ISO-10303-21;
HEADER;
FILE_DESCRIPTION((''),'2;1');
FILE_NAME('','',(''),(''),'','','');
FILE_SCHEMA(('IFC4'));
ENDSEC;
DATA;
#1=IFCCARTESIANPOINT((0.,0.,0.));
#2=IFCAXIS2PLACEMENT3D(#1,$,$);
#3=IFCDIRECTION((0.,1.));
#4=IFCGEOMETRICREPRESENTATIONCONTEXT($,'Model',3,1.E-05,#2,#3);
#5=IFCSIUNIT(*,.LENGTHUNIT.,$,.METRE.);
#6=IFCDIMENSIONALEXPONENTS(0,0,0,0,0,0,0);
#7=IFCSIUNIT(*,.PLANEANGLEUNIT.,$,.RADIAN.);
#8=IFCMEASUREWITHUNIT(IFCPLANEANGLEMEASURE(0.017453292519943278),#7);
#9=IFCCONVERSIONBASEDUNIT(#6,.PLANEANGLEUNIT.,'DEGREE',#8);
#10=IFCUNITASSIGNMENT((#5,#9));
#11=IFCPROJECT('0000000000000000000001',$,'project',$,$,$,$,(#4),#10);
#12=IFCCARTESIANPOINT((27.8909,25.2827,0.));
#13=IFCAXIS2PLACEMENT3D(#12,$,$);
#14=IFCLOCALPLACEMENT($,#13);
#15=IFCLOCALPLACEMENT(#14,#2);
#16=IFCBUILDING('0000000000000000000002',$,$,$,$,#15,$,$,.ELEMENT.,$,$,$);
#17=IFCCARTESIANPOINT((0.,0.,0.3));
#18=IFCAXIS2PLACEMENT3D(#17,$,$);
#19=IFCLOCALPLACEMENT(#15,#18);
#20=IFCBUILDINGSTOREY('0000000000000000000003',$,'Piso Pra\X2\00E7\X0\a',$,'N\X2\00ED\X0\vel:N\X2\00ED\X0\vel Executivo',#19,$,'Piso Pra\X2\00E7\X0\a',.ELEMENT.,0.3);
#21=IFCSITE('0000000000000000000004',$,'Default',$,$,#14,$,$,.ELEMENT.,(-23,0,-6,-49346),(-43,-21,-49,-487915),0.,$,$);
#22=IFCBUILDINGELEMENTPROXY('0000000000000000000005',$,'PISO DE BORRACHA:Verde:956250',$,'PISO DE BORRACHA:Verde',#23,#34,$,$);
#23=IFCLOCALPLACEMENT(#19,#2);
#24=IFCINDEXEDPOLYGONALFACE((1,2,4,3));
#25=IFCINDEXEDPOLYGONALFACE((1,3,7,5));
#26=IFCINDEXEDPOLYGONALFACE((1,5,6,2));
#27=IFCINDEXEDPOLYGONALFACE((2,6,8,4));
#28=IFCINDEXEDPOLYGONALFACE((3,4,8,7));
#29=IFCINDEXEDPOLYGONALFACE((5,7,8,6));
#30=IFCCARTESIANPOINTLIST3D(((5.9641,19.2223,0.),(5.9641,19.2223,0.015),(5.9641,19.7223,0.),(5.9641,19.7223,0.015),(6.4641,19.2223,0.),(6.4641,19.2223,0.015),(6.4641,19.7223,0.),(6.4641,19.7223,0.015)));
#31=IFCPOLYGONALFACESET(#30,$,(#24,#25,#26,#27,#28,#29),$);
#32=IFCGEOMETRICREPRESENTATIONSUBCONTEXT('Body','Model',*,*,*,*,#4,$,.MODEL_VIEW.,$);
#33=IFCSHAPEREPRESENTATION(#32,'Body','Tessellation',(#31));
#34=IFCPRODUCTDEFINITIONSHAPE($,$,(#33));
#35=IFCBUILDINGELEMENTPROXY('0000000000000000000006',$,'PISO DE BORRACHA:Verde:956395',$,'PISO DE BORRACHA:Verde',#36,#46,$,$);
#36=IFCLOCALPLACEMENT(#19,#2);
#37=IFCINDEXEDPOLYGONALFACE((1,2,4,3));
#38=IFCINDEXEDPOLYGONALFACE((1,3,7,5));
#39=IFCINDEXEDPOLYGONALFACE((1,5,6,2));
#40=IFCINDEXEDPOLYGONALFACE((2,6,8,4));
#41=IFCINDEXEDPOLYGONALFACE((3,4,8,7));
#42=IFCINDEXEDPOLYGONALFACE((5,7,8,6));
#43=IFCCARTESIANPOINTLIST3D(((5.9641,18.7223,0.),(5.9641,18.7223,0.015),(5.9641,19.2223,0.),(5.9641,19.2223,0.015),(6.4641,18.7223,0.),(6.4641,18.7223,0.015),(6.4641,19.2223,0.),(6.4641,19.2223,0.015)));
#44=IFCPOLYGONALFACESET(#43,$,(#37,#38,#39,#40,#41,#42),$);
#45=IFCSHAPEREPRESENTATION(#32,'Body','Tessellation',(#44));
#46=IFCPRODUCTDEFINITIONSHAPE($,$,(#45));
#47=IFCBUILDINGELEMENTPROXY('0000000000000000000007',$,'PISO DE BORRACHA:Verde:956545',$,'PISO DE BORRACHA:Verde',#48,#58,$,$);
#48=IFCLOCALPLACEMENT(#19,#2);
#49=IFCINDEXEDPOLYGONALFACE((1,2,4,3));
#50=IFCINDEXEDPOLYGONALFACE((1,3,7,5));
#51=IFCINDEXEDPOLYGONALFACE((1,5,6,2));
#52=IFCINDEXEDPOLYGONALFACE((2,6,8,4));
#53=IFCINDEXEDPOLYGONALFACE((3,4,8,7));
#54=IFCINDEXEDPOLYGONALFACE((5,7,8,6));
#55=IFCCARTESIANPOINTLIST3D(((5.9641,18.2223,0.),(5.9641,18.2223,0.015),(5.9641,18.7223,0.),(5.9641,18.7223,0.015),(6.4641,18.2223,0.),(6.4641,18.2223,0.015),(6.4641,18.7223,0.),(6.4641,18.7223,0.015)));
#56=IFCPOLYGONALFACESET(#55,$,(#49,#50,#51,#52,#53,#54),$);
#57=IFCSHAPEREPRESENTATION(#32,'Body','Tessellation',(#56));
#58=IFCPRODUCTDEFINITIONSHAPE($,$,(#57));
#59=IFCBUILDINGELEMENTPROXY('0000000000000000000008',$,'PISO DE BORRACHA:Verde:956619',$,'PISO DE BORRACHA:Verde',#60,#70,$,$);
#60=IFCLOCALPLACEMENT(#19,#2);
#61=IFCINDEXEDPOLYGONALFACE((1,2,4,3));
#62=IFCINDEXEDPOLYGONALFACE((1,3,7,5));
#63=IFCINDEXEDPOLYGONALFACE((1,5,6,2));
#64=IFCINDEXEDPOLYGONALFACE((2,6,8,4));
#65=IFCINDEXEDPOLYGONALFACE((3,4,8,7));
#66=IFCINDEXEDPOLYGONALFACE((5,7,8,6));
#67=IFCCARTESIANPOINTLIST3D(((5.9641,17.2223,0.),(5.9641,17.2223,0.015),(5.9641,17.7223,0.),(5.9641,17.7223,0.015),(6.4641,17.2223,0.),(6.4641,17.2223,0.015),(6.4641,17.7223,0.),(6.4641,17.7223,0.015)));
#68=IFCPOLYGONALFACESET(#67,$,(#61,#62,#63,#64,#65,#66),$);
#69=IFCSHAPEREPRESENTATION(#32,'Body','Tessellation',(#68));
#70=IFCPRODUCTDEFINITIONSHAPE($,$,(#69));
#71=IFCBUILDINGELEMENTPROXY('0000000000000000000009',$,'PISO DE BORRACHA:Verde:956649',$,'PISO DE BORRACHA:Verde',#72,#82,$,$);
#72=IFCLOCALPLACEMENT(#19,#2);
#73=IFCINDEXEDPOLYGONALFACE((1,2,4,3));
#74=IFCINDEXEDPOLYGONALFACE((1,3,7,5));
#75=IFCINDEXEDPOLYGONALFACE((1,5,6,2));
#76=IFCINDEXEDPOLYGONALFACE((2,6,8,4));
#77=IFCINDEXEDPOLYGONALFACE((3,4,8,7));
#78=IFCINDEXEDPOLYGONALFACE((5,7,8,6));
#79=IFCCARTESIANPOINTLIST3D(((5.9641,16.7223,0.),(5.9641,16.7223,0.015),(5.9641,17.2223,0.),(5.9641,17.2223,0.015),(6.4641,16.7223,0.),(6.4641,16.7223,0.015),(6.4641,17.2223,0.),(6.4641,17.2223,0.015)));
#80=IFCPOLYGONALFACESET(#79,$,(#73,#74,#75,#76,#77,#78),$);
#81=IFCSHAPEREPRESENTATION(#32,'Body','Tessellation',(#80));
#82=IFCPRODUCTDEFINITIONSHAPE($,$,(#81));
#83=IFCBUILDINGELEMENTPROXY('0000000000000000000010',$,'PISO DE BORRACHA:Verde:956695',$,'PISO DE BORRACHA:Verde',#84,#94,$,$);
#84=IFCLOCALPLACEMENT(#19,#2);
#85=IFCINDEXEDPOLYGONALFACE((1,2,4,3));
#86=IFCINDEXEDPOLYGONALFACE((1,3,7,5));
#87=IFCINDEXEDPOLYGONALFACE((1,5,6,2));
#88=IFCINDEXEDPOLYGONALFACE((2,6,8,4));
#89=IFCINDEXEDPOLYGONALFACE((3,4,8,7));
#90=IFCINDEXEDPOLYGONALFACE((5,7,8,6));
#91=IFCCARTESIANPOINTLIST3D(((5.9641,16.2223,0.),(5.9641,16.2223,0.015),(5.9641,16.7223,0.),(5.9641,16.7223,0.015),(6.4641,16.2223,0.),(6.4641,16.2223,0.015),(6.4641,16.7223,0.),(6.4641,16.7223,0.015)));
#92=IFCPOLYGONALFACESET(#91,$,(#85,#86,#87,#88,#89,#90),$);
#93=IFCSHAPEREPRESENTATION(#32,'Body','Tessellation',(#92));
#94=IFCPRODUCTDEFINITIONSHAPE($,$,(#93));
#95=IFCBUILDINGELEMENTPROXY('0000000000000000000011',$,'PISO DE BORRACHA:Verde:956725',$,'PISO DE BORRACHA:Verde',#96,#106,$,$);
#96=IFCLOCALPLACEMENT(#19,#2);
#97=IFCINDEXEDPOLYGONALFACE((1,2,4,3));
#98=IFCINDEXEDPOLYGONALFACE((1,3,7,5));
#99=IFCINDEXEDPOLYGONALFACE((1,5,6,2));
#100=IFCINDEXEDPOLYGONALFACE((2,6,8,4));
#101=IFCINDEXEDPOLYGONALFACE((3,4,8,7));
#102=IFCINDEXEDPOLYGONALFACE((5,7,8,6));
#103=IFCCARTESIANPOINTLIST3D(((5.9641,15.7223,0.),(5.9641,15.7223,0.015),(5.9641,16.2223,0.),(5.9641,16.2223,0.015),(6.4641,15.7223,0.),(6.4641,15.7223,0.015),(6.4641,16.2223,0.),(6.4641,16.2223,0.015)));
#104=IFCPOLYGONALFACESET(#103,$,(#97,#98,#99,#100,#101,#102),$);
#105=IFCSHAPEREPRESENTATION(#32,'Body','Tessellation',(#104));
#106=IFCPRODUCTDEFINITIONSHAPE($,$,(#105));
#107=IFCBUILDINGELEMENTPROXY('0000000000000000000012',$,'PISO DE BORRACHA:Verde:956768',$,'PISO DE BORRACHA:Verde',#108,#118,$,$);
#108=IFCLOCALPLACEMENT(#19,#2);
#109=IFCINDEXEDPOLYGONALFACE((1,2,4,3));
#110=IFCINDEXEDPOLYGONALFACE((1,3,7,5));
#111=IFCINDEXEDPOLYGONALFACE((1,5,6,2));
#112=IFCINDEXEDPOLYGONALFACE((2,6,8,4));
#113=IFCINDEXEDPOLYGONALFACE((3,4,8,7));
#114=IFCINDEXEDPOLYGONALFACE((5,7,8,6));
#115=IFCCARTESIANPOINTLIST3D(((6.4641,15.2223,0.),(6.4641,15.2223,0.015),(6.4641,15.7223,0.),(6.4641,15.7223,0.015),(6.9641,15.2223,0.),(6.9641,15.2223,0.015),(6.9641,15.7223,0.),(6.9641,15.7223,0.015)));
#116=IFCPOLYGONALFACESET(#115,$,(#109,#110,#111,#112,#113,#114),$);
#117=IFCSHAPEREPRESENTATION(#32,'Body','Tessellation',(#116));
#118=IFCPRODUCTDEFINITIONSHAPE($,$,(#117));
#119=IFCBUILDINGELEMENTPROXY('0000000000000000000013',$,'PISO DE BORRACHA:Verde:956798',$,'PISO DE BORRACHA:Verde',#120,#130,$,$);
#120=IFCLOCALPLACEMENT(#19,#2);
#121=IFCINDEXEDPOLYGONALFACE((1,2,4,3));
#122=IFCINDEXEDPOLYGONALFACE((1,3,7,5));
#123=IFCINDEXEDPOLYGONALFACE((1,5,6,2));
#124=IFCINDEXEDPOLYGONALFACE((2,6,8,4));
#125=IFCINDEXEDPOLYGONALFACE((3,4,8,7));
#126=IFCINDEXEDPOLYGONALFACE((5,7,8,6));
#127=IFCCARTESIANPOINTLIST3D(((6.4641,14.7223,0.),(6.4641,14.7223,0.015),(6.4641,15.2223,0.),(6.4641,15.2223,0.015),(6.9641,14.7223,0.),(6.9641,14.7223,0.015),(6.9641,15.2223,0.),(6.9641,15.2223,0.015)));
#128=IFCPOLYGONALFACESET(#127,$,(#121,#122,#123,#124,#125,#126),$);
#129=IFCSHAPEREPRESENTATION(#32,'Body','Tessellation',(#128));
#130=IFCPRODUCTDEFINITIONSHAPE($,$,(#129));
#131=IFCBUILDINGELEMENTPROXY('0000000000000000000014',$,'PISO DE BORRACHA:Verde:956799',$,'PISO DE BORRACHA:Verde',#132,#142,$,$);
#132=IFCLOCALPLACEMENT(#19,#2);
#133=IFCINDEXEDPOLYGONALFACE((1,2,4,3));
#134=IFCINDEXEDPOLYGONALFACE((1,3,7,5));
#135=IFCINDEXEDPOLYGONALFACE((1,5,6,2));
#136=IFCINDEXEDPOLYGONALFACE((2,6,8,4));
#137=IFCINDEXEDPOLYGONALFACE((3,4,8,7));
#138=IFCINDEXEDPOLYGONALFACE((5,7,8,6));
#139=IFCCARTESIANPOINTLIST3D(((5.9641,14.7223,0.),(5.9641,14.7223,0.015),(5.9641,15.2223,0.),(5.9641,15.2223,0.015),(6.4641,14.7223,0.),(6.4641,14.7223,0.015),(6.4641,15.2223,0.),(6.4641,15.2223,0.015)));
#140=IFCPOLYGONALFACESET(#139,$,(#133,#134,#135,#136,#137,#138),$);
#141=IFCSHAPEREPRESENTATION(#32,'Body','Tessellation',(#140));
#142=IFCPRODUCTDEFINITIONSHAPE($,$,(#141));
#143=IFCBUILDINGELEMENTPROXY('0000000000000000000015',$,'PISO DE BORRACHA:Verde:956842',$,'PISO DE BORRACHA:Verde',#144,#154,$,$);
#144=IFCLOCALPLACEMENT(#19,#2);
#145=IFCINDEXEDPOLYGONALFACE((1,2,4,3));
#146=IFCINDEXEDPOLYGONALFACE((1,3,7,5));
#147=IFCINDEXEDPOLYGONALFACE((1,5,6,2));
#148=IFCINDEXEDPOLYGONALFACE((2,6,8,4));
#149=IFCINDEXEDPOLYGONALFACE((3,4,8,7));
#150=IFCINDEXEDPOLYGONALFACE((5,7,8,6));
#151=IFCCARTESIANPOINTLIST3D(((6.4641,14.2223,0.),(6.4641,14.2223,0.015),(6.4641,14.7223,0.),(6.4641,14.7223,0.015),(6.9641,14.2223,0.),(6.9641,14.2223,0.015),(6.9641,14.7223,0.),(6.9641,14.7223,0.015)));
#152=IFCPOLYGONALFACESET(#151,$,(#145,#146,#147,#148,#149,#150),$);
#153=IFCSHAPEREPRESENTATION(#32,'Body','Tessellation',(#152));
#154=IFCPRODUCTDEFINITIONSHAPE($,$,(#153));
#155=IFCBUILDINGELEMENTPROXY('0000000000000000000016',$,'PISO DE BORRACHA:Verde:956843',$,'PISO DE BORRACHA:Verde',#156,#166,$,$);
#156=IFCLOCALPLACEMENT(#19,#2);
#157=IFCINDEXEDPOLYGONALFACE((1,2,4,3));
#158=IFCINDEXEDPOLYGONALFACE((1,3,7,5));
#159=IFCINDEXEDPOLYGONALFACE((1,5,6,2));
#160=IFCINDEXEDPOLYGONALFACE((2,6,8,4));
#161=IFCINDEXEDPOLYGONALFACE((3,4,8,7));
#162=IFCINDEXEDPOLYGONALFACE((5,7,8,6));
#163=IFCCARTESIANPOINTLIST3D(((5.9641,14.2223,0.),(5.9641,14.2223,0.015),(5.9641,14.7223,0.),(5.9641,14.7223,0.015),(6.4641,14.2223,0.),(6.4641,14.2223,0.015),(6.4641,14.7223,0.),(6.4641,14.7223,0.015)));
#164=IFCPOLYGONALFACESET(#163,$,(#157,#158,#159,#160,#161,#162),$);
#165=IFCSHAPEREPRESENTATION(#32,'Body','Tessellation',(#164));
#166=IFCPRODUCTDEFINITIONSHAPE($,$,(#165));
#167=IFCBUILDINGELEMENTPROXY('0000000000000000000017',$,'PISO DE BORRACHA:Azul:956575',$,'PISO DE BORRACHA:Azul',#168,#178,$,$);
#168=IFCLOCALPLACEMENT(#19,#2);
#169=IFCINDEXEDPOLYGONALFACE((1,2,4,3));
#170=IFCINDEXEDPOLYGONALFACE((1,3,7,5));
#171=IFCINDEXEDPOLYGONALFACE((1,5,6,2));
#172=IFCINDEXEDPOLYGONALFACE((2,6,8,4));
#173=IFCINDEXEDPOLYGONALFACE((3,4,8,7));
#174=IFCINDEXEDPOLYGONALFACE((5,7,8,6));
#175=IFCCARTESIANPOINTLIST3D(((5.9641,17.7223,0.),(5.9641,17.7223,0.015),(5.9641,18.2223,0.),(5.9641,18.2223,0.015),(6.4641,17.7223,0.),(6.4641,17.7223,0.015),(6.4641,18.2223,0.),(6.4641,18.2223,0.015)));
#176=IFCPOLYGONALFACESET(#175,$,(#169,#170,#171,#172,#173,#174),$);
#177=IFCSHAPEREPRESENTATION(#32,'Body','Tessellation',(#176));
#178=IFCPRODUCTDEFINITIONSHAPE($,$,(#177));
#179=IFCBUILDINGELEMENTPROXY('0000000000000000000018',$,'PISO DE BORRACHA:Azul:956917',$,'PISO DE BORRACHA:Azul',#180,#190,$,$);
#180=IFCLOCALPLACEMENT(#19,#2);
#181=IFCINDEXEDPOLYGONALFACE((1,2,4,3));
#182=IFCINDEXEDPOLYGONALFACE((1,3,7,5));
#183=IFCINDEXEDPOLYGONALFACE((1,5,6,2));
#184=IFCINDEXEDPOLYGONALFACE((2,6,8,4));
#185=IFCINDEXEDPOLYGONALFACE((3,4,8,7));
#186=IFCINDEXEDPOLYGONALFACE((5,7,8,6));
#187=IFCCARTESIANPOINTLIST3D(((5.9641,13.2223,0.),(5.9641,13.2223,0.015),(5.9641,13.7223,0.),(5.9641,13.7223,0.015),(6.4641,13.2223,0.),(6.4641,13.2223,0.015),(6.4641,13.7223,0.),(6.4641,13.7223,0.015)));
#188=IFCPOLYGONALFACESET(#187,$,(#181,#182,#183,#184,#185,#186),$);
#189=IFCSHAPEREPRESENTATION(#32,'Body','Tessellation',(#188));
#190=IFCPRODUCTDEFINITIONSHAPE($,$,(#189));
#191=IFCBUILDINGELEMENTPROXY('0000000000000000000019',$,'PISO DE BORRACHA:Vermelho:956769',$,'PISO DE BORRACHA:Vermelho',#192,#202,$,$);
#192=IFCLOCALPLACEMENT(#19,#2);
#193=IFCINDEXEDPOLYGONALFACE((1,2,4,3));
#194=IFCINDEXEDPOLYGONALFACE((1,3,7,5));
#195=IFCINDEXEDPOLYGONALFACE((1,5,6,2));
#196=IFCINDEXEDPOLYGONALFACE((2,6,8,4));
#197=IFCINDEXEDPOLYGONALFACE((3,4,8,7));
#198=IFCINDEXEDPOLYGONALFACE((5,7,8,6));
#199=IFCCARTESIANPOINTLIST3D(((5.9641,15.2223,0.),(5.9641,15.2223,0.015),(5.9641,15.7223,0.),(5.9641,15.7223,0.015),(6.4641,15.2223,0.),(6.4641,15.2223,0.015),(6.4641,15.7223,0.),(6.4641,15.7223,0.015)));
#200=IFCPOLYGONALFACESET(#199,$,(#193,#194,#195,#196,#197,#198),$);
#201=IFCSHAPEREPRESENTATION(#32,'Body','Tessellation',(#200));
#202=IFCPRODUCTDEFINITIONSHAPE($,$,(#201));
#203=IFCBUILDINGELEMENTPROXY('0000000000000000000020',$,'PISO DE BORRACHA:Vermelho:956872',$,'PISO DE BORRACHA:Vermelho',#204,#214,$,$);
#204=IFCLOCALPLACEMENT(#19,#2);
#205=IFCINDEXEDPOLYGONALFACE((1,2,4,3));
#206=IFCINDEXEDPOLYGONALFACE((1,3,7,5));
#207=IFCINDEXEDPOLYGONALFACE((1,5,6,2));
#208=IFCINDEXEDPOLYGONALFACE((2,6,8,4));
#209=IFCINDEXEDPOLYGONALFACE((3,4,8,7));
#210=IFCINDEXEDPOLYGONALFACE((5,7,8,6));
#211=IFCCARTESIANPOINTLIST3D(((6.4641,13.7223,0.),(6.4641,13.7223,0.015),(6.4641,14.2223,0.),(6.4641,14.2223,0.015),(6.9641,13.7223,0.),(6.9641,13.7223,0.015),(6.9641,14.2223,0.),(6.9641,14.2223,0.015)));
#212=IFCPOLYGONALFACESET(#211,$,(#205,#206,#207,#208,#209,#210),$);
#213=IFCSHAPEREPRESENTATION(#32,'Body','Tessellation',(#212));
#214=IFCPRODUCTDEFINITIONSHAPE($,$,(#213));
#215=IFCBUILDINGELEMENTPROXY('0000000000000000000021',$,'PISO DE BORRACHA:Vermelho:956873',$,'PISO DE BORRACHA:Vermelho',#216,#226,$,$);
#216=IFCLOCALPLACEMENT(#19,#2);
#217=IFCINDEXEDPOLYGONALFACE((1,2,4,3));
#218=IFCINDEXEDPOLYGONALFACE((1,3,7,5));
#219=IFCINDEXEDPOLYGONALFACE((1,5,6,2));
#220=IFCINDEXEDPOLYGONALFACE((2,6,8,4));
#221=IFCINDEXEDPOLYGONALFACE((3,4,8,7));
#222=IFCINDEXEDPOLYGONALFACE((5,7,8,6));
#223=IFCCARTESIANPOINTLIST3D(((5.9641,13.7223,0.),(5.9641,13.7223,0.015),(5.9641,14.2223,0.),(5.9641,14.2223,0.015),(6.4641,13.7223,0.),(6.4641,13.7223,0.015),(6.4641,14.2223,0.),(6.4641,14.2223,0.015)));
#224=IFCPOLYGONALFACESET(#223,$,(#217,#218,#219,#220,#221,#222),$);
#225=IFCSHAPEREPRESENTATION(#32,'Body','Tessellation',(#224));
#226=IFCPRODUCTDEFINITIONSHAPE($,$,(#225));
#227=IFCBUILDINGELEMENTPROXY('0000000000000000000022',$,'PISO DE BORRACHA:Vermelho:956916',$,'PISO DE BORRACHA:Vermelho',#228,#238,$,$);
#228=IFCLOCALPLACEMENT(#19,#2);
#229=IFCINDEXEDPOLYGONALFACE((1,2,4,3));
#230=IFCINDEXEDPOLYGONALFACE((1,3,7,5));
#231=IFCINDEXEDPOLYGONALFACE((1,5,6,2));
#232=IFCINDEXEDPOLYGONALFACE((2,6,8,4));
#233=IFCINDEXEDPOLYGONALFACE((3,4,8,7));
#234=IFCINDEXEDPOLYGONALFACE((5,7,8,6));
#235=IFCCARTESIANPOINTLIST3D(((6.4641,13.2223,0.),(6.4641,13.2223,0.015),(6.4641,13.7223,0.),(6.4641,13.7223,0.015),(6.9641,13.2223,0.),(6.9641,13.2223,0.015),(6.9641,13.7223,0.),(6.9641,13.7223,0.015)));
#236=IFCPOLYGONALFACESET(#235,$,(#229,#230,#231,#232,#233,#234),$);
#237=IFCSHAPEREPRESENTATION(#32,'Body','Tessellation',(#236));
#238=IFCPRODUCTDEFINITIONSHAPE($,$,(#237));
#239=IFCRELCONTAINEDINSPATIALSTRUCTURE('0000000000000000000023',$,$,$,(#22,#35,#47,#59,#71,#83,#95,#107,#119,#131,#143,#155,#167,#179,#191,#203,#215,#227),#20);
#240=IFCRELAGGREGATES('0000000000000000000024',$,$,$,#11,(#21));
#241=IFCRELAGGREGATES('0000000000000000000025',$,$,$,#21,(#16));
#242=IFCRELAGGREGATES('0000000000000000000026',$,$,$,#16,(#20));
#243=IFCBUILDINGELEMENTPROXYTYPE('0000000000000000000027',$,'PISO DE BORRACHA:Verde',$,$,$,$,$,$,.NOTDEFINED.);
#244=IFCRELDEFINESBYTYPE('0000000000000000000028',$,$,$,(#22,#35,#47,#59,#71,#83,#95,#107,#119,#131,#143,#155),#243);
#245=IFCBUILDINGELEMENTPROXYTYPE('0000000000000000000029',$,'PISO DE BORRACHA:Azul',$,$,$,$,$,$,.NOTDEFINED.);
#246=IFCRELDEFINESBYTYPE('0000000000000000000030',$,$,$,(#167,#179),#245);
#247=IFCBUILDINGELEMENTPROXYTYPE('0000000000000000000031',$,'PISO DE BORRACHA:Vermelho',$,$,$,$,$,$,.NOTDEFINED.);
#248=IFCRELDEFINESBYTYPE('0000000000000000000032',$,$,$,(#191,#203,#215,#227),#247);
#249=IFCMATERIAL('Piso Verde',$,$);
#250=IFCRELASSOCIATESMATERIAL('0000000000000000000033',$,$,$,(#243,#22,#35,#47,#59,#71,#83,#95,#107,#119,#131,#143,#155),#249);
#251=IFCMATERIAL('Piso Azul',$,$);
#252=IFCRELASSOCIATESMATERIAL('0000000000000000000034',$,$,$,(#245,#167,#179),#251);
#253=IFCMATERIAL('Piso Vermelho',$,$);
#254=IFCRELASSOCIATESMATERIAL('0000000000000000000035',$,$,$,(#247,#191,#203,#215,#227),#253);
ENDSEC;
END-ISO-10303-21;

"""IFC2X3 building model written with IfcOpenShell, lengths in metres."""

from ifc_helpers import new_model, entity, si_unit, converted_unit, direction, frame, origin, origin_2d_with_axis, place, context, subcontext, project, spatial, rectangle, extrude, source, transform, mapped, material, type_object, type_shapes, element, save


model = new_model("IFC2X3")

# Units and contexts
model_context = context("Model", 3, precision=1e-05, world=origin(), true_north=direction((0.0, 1.0)))
body_context = subcontext(model_context, "Body", "Model", "MODEL_VIEW")
ifc_project = project(units=[si_unit("LENGTHUNIT", "METRE"), converted_unit("PLANEANGLEUNIT", "DEGREE", entity("IfcPlaneAngleMeasure", 0.017453292519943278), si_unit("PLANEANGLEUNIT", "RADIAN"), dimensions=[0, 0, 0, 0, 0, 0, 0])], contexts=[model_context])

# Site, building, storey
site_placement = place(None, frame((27.8909, 25.2827, 0.0)))
site = spatial("IfcSite", under=ifc_project, at=site_placement, Name="Default", CompositionType="ELEMENT", RefLatitude=(-23, 0, -6, -49346), RefLongitude=(-43, -21, -49, -487915), RefElevation=0.0)
building_placement = place(site_placement, origin())
building = spatial("IfcBuilding", under=site, at=building_placement, CompositionType="ELEMENT")
storey_placement = place(building_placement, frame((0.0, 0.0, 0.3)))
storey = spatial("IfcBuildingStorey", under=building, at=storey_placement, Name="Piso Praça", ObjectType="Nível:Nível Executivo", LongName="Piso Praça", CompositionType="ELEMENT", Elevation=0.3)

# Building element proxies
ifc_material_1 = material(Name="Piso Verde")
building_element_proxy_type_1 = type_object("IfcBuildingElementProxyType", Name="PISO DE BORRACHA:Verde", PredefinedType="NOTDEFINED", material=ifc_material_1)
shared_shape_1 = source(origin(), body_context, "Body", "SweptSolid", [
    extrude(rectangle(XDim=0.5, YDim=0.5, at=origin_2d_with_axis()), frame((0.25, 0.25, 0.0), z_axis=(0.0, 0.0, 1.0), x_axis=(-1.0, 0.0, 0.0)), (0.0, 0.0, 1.0), 0.015),
])
type_shapes(building_element_proxy_type_1, [shared_shape_1])
for number, where, name in (
    (1, (5.9641, 19.2223, 0.0), "PISO DE BORRACHA:Verde:956250"),
    (2, (5.9641, 18.7223, 0.0), "PISO DE BORRACHA:Verde:956395"),
    (3, (5.9641, 18.2223, 0.0), "PISO DE BORRACHA:Verde:956545"),
    (4, (5.9641, 17.2223, 0.0), "PISO DE BORRACHA:Verde:956619"),
    (5, (5.9641, 16.7223, 0.0), "PISO DE BORRACHA:Verde:956649"),
    (6, (5.9641, 16.2223, 0.0), "PISO DE BORRACHA:Verde:956695"),
    (7, (5.9641, 15.7223, 0.0), "PISO DE BORRACHA:Verde:956725"),
    (8, (6.4641, 15.2223, 0.0), "PISO DE BORRACHA:Verde:956768"),
    (9, (6.4641, 14.7223, 0.0), "PISO DE BORRACHA:Verde:956798"),
    (10, (5.9641, 14.7223, 0.0), "PISO DE BORRACHA:Verde:956799"),
    (11, (6.4641, 14.2223, 0.0), "PISO DE BORRACHA:Verde:956842"),
    (12, (5.9641, 14.2223, 0.0), "PISO DE BORRACHA:Verde:956843"),
):
    element("IfcBuildingElementProxy", number, at=place(storey_placement, frame(where)), inside=storey, type_object=building_element_proxy_type_1, material=ifc_material_1, Name=name, ObjectType="PISO DE BORRACHA:Verde", context=body_context, shape_type="MappedRepresentation", body=[
        mapped(shared_shape_1, transform((0.0, 0.0, 0.0), scale=1.0)),
    ])
ifc_material_2 = material(Name="Piso Azul")
building_element_proxy_type_2 = type_object("IfcBuildingElementProxyType", Name="PISO DE BORRACHA:Azul", PredefinedType="NOTDEFINED", material=ifc_material_2)
shared_shape_2 = source(origin(), body_context, "Body", "SweptSolid", [
    extrude(rectangle(XDim=0.5, YDim=0.5, at=origin_2d_with_axis()), frame((0.25, 0.25, 0.0), z_axis=(0.0, 0.0, 1.0), x_axis=(-1.0, 0.0, 0.0)), (0.0, 0.0, 1.0), 0.015),
])
type_shapes(building_element_proxy_type_2, [shared_shape_2])
for number, where, name in (
    (13, (5.9641, 17.7223, 0.0), "PISO DE BORRACHA:Azul:956575"),
    (14, (5.9641, 13.2223, 0.0), "PISO DE BORRACHA:Azul:956917"),
):
    element("IfcBuildingElementProxy", number, at=place(storey_placement, frame(where)), inside=storey, type_object=building_element_proxy_type_2, material=ifc_material_2, Name=name, ObjectType="PISO DE BORRACHA:Azul", context=body_context, shape_type="MappedRepresentation", body=[
        mapped(shared_shape_2, transform((0.0, 0.0, 0.0), scale=1.0)),
    ])
ifc_material_3 = material(Name="Piso Vermelho")
building_element_proxy_type_3 = type_object("IfcBuildingElementProxyType", Name="PISO DE BORRACHA:Vermelho", PredefinedType="NOTDEFINED", material=ifc_material_3)
shared_shape_3 = source(origin(), body_context, "Body", "SweptSolid", [
    extrude(rectangle(XDim=0.5, YDim=0.5, at=origin_2d_with_axis()), frame((0.25, 0.25, 0.0), z_axis=(0.0, 0.0, 1.0), x_axis=(-1.0, 0.0, 0.0)), (0.0, 0.0, 1.0), 0.015),
])
type_shapes(building_element_proxy_type_3, [shared_shape_3])
for number, where, name in (
    (15, (5.9641, 15.2223, 0.0), "PISO DE BORRACHA:Vermelho:956769"),
    (16, (6.4641, 13.7223, 0.0), "PISO DE BORRACHA:Vermelho:956872"),
    (17, (5.9641, 13.7223, 0.0), "PISO DE BORRACHA:Vermelho:956873"),
    (18, (6.4641, 13.2223, 0.0), "PISO DE BORRACHA:Vermelho:956916"),
):
    element("IfcBuildingElementProxy", number, at=place(storey_placement, frame(where)), inside=storey, type_object=building_element_proxy_type_3, material=ifc_material_3, Name=name, ObjectType="PISO DE BORRACHA:Vermelho", context=body_context, shape_type="MappedRepresentation", body=[
        mapped(shared_shape_3, transform((0.0, 0.0, 0.0), scale=1.0)),
    ])

save(model, "model.ifc")
